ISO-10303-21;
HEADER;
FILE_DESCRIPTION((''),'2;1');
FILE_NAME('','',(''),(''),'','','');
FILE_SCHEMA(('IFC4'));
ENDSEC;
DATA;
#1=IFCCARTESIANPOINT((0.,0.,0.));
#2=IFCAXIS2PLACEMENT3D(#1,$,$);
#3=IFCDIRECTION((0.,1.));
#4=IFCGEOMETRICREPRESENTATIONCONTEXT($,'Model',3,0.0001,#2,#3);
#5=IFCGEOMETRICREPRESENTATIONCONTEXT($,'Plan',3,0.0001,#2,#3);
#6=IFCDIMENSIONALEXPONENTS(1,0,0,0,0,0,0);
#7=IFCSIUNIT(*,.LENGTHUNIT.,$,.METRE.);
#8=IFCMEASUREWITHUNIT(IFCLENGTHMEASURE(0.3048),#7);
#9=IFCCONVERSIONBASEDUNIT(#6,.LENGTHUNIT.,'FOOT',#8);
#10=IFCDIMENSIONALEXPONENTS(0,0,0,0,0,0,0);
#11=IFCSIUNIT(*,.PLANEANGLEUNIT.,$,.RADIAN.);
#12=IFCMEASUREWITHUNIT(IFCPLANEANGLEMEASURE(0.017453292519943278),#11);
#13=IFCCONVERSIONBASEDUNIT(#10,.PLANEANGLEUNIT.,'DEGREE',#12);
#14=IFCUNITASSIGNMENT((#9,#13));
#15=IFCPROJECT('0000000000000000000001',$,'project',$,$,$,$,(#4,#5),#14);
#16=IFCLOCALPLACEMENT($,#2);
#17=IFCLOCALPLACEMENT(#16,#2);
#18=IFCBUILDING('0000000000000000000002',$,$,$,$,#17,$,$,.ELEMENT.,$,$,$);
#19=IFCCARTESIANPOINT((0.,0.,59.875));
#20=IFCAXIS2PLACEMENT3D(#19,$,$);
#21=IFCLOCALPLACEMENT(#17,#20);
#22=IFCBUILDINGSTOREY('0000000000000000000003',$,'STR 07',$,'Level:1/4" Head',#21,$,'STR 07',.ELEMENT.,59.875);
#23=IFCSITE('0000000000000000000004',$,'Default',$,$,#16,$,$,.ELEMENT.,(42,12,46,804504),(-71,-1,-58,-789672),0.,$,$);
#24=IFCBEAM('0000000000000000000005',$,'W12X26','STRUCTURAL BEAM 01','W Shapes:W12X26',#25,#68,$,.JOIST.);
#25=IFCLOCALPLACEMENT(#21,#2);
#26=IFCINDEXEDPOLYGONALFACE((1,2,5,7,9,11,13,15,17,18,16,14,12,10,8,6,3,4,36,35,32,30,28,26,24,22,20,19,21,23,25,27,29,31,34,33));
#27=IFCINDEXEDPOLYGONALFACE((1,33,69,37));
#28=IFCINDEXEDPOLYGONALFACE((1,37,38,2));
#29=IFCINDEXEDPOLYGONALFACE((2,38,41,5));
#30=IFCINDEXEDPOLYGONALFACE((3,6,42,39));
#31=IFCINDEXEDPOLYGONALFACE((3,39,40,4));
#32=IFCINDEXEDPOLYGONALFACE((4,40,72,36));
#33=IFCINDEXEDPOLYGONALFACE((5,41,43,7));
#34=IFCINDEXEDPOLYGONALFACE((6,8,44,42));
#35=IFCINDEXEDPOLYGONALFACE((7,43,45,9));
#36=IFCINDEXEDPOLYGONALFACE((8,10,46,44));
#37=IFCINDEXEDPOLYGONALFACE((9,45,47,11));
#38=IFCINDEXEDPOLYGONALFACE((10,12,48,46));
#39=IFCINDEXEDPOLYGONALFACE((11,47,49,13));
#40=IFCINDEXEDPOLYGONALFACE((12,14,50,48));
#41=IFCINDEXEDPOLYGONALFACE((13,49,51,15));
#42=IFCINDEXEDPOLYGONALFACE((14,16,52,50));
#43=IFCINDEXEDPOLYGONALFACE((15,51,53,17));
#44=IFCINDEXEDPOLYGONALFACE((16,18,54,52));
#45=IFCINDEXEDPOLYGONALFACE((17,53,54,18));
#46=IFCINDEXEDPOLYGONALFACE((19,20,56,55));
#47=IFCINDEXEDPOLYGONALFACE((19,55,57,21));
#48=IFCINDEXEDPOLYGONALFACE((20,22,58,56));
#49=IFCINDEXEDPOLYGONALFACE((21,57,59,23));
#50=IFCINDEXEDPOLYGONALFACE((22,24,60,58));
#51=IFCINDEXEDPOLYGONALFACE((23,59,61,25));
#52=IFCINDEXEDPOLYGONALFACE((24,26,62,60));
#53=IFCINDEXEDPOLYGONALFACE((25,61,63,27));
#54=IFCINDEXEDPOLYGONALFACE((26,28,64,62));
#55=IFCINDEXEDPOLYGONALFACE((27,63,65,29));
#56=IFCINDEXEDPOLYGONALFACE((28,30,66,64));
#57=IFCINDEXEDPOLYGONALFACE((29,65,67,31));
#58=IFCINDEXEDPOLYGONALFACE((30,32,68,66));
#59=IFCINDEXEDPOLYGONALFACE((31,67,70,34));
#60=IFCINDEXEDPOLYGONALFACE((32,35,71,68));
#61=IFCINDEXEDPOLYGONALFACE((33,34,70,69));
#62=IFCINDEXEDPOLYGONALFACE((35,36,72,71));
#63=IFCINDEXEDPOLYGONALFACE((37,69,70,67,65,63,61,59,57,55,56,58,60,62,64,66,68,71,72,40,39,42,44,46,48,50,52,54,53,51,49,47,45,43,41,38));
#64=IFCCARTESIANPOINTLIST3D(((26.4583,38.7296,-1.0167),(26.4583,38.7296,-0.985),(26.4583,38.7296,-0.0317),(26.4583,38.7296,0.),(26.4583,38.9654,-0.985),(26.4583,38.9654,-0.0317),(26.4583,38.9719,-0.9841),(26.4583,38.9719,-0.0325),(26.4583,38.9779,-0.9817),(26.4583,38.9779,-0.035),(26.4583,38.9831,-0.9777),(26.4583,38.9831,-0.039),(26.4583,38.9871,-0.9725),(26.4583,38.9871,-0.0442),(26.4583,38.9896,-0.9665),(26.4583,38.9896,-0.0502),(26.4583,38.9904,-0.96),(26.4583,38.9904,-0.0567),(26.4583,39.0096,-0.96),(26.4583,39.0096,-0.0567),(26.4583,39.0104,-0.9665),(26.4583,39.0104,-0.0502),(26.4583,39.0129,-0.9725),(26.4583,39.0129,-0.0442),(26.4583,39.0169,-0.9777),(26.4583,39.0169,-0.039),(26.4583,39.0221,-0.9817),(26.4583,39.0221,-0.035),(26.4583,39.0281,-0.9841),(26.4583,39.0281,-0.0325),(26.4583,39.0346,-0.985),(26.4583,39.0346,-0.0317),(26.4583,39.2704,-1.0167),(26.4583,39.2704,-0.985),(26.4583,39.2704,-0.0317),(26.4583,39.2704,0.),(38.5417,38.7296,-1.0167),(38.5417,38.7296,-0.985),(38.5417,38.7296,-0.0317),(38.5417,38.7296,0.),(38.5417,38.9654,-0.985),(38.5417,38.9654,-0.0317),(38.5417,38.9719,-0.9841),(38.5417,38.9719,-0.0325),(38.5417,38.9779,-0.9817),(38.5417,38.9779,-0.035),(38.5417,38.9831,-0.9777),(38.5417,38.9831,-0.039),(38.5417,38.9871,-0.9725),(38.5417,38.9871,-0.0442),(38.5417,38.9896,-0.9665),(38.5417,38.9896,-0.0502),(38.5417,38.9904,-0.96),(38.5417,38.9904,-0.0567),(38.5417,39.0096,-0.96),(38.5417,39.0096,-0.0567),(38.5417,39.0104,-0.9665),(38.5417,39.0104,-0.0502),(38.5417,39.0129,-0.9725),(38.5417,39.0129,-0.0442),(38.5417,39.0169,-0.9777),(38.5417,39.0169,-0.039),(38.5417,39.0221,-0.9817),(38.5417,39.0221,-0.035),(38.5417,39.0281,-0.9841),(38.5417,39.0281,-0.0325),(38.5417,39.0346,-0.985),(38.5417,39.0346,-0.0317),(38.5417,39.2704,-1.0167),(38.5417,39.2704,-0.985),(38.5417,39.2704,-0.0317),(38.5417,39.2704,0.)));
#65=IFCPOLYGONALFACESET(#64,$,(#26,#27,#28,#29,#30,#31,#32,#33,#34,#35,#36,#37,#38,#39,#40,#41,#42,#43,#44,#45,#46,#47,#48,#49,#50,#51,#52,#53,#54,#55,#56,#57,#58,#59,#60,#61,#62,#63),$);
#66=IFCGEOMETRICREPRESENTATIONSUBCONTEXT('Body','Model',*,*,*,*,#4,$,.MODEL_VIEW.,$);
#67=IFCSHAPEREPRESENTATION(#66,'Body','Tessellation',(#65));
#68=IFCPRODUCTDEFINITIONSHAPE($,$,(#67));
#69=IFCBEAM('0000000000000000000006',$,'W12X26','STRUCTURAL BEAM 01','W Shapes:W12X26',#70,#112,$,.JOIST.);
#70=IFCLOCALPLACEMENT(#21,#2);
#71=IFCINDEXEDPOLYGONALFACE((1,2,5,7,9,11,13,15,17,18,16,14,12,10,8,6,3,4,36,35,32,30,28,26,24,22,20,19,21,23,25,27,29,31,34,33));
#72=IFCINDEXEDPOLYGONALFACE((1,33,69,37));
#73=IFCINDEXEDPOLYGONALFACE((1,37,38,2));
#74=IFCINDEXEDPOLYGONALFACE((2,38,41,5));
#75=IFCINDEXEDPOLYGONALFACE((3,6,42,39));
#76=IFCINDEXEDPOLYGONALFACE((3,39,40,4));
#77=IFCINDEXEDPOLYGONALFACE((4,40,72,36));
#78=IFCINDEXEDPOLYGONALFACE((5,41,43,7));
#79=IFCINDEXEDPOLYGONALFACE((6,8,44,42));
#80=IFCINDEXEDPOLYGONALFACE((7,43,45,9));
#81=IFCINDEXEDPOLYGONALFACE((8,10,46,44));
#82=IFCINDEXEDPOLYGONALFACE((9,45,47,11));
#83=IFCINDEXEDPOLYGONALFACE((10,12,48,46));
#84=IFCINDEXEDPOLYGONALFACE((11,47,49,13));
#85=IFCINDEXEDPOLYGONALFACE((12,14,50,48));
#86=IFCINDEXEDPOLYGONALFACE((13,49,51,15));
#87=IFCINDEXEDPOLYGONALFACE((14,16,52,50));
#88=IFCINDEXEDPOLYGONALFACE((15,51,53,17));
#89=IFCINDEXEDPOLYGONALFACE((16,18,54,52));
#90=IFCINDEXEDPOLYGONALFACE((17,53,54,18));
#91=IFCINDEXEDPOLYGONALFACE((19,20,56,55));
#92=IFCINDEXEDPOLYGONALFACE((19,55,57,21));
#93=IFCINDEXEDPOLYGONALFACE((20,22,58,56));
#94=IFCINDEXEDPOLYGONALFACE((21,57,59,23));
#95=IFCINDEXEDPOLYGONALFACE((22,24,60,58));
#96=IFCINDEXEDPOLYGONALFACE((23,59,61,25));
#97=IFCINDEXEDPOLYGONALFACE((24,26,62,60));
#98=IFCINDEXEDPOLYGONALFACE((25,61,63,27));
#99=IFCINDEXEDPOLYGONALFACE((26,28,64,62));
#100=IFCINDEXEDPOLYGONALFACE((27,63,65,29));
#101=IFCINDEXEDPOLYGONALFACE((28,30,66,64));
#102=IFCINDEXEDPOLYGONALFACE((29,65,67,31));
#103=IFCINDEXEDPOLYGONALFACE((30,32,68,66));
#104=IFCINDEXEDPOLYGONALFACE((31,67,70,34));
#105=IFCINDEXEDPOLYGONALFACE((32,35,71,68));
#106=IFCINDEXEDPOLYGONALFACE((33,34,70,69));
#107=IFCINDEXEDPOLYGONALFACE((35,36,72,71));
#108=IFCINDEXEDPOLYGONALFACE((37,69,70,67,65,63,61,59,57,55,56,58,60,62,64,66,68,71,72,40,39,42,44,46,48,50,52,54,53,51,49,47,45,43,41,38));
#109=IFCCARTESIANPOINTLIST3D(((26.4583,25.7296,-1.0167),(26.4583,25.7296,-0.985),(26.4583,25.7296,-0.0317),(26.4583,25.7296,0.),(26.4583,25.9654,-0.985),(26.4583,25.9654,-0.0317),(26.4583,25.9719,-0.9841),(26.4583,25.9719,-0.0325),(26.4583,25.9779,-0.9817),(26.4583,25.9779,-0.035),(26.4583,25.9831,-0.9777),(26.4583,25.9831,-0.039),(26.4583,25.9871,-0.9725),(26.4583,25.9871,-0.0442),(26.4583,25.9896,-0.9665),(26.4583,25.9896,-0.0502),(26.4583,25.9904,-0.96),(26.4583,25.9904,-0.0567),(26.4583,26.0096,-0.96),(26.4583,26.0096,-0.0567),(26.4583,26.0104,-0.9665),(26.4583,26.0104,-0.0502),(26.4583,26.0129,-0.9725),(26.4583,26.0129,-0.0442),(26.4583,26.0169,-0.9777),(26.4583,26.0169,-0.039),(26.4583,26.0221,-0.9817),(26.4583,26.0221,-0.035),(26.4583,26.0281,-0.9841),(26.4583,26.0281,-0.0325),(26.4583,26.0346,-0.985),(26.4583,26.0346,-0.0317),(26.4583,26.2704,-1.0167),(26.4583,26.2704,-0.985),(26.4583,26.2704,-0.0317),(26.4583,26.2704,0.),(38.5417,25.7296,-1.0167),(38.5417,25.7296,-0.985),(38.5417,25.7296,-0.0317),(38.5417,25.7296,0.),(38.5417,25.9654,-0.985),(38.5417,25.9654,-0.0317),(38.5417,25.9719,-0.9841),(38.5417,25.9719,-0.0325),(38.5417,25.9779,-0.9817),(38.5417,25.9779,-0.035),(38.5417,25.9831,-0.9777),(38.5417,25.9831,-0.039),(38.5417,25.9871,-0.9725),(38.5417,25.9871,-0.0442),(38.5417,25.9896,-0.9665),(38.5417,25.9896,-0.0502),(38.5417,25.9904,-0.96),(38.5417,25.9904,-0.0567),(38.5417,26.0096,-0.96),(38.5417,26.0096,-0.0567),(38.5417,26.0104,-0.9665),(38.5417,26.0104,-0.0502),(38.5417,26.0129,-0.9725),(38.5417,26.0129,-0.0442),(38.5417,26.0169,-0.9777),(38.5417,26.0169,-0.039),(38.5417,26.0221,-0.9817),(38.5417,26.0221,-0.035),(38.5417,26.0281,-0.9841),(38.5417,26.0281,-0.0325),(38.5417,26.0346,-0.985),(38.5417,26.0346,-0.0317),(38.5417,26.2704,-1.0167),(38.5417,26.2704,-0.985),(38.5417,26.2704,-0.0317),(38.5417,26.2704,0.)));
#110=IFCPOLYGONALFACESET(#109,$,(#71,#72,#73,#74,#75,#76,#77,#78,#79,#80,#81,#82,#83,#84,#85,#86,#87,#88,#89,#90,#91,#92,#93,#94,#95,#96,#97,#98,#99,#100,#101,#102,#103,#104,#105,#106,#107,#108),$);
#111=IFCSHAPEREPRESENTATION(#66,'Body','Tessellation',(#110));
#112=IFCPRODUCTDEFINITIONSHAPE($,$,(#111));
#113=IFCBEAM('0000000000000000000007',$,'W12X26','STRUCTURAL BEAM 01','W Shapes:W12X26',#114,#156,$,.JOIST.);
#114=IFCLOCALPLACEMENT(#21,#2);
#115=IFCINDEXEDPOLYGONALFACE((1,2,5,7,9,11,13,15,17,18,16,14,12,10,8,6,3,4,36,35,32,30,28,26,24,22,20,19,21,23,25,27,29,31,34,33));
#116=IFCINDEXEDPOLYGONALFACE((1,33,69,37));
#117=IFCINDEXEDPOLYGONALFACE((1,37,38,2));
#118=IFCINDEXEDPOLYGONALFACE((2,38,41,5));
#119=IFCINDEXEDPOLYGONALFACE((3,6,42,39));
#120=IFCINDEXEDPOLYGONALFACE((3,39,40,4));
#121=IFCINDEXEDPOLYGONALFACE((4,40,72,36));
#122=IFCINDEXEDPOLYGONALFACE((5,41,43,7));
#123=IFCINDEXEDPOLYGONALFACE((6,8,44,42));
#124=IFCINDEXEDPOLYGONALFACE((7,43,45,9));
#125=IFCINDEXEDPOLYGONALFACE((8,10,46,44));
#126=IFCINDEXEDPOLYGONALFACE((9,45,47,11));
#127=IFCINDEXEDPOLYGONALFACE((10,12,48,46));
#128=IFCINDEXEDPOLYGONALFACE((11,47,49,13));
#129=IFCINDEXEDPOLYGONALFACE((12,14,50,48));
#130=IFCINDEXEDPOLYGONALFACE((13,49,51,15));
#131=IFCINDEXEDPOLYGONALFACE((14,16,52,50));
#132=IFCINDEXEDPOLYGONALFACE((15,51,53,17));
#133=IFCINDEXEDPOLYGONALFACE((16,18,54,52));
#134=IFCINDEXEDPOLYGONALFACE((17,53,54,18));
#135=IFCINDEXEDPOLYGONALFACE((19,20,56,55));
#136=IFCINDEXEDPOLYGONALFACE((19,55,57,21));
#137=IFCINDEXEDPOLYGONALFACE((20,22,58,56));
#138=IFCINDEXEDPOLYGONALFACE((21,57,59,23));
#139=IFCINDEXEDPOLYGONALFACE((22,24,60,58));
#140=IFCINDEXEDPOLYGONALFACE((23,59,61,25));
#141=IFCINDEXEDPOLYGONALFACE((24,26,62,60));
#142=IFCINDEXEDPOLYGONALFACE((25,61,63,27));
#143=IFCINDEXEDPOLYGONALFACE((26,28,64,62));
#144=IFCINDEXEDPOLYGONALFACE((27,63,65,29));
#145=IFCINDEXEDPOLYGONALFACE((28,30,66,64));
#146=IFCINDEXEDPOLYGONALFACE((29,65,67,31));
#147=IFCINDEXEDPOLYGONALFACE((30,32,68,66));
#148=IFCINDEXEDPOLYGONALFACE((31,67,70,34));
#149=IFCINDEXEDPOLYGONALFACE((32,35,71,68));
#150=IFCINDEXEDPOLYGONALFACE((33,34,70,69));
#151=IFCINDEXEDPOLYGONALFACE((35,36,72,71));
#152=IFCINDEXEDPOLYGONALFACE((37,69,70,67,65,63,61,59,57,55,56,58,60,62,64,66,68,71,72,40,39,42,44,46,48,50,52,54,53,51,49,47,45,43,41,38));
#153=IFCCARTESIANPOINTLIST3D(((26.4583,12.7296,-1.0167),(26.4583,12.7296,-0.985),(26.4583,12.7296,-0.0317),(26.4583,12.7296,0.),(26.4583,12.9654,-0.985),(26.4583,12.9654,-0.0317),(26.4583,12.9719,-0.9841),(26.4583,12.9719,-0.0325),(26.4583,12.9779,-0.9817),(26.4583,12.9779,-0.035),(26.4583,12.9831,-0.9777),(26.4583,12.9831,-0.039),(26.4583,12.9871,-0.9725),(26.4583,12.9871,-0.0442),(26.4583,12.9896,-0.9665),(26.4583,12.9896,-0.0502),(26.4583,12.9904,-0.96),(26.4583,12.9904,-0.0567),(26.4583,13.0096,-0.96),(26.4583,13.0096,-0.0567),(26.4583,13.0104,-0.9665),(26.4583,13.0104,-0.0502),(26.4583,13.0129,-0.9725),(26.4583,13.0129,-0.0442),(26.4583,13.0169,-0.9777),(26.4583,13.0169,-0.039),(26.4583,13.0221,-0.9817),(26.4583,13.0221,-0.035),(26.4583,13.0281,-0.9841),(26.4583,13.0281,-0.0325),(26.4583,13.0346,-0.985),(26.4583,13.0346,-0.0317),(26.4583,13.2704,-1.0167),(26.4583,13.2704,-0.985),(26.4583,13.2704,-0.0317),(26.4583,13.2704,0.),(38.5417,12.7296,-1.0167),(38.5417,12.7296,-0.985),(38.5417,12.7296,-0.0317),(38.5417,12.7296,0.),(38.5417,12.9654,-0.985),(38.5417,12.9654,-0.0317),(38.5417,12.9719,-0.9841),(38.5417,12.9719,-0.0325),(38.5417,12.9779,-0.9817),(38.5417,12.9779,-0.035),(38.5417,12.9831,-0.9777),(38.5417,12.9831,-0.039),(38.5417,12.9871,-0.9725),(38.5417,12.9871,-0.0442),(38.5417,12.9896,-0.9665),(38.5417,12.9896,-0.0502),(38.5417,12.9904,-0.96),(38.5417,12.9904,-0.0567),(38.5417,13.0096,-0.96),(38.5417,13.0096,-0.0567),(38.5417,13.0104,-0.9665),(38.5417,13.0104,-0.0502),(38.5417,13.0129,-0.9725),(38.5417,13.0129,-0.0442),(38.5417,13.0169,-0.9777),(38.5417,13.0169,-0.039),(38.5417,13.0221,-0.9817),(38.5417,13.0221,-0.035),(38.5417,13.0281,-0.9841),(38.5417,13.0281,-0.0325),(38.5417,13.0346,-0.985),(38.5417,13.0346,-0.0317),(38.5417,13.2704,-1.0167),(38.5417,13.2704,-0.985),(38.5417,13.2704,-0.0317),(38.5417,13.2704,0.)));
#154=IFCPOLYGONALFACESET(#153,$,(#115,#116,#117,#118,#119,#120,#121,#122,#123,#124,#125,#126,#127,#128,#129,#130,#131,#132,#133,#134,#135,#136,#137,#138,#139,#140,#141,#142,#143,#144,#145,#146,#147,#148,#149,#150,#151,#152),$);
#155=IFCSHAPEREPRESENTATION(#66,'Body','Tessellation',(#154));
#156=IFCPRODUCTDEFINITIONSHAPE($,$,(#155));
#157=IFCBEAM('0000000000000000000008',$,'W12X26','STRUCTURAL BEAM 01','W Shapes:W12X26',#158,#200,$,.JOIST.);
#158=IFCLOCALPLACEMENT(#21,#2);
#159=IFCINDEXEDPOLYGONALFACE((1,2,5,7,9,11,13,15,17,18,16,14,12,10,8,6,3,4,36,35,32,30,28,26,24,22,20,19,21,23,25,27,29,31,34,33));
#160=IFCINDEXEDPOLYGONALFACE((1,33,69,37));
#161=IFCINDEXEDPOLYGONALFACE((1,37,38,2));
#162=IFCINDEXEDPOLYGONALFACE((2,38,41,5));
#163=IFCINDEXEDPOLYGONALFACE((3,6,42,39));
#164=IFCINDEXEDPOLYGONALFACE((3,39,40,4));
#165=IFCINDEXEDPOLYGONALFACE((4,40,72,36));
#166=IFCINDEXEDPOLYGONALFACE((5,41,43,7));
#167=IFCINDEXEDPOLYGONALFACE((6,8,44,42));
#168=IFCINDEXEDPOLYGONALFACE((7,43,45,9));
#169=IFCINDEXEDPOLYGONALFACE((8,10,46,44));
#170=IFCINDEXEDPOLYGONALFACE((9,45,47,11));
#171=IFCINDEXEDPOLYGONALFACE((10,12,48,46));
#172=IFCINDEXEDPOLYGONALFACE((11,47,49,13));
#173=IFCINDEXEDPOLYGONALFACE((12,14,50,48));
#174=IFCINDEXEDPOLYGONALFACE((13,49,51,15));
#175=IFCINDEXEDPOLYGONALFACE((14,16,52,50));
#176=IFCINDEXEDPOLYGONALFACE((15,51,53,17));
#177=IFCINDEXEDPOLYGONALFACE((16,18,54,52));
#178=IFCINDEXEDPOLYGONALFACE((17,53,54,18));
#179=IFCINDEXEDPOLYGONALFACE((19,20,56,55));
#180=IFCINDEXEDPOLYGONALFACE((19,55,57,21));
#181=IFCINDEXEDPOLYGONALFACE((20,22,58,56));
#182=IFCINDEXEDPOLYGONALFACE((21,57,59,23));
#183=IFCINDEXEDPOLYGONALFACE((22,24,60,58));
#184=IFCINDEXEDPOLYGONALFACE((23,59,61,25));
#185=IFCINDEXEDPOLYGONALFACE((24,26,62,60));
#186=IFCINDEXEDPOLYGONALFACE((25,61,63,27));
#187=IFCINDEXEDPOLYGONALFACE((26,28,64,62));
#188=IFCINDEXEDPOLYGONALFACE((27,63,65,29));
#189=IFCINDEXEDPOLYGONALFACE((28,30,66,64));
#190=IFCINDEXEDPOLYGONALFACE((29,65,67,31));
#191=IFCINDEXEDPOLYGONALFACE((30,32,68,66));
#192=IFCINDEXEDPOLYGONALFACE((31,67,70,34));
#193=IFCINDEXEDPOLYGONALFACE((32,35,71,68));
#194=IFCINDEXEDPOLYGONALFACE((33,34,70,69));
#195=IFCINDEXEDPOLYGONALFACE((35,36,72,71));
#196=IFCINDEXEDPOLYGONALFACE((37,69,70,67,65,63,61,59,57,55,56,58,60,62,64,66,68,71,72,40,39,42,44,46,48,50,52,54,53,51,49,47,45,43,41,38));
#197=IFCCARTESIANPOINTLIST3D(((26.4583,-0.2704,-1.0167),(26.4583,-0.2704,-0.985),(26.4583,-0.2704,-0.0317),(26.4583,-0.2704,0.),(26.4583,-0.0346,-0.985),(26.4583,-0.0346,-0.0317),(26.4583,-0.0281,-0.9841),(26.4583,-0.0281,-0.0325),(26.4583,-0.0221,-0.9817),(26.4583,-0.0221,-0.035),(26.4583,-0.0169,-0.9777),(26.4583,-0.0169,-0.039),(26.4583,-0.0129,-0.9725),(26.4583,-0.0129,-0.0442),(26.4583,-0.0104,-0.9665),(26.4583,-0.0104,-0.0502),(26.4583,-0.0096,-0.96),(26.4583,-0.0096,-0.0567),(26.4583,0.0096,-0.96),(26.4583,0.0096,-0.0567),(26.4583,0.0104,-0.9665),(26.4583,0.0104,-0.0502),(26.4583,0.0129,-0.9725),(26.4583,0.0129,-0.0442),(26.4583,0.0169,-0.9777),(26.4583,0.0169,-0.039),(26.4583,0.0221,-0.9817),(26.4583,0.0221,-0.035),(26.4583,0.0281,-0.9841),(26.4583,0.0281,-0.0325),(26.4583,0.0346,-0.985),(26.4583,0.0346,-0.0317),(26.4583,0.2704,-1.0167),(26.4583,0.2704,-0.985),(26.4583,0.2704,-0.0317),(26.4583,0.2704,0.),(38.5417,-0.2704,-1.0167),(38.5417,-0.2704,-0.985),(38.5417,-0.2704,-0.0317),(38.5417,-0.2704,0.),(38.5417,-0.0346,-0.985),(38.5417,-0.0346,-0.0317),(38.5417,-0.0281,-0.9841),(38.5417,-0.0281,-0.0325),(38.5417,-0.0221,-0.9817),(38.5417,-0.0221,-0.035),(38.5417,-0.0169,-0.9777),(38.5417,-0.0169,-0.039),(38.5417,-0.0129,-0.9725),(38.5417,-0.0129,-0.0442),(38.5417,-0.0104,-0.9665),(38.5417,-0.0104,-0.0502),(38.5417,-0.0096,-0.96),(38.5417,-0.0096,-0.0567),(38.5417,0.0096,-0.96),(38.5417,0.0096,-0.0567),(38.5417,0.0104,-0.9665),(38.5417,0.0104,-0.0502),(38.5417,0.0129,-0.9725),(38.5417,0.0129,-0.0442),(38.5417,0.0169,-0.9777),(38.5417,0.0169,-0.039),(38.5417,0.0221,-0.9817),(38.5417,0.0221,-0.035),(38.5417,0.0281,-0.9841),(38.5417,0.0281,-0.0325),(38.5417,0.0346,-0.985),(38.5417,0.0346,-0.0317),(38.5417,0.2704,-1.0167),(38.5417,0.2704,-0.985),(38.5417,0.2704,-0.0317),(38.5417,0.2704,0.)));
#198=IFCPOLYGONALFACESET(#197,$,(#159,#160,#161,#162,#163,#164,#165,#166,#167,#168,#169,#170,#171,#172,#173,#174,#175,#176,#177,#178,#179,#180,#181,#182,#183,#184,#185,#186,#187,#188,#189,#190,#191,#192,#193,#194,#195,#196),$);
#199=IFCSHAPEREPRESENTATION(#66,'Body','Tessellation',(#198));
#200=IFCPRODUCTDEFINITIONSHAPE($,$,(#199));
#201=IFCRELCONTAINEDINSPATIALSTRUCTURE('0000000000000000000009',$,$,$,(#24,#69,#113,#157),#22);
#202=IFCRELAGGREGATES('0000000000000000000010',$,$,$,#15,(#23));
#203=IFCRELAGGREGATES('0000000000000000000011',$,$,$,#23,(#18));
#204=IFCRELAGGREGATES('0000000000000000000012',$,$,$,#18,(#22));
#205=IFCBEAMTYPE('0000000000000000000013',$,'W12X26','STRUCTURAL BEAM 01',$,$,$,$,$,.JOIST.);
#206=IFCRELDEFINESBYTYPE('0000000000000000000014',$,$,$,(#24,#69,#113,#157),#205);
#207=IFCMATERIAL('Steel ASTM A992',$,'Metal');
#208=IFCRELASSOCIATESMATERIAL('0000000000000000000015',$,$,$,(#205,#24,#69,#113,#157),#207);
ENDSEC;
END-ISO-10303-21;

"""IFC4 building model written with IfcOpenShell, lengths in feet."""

from ifc_helpers import new_model, entity, si_unit, converted_unit, direction, frame, origin, place, context, subcontext, project, spatial, line, arc, indexed_curve, outline, extrude, source, transform, mapped, material, type_object, type_shapes, element, save


model = new_model("IFC4")

# Units and contexts
model_context = context("Model", 3, precision=0.0001, world=origin(), true_north=direction((0.0, 1.0)))
plan_context = context("Plan", 3, precision=0.0001, world=origin(), true_north=direction((0.0, 1.0)))
body_context = subcontext(model_context, "Body", "Model", "MODEL_VIEW")
ifc_project = project(units=[converted_unit("LENGTHUNIT", "FOOT", entity("IfcLengthMeasure", 0.3048), si_unit("LENGTHUNIT", "METRE"), dimensions=[1, 0, 0, 0, 0, 0, 0]), converted_unit("PLANEANGLEUNIT", "DEGREE", entity("IfcPlaneAngleMeasure", 0.017453292519943278), si_unit("PLANEANGLEUNIT", "RADIAN"), dimensions=[0, 0, 0, 0, 0, 0, 0])], contexts=[model_context, plan_context])

# Site, building, storey
site_placement = place(None, origin())
site = spatial("IfcSite", under=ifc_project, at=site_placement, Name="Default", CompositionType="ELEMENT", RefLatitude=(42, 12, 46, 804504), RefLongitude=(-71, -1, -58, -789672), RefElevation=0.0)
building_placement = place(site_placement, origin())
building = spatial("IfcBuilding", under=site, at=building_placement, CompositionType="ELEMENT")
storey_placement = place(building_placement, frame((0.0, 0.0, 59.875)))
storey = spatial("IfcBuildingStorey", under=building, at=storey_placement, Name="STR 07", ObjectType="Level:1/4\" Head", LongName="STR 07", CompositionType="ELEMENT", Elevation=59.875)

# Shared definitions
ifc_material = material(Name="Steel ASTM A992", Category="Metal")

# Beams
beam_type_1 = type_object("IfcBeamType", Name="W12X26", Description="STRUCTURAL BEAM 01", PredefinedType="JOIST", material=ifc_material)
shared_shape_1 = source(origin(), body_context, "Body", "SweptSolid", [
    extrude(outline(indexed_curve([(-0.2704, -0.4767), (-0.2704, -0.5083), (0.2704, -0.5083), (0.2704, -0.4767), (0.0346, -0.4767), (0.0169, -0.4693), (0.0096, -0.4517), (0.0096, 0.4517), (0.0169, 0.4693), (0.0346, 0.4767), (0.2704, 0.4767), (0.2704, 0.5083), (-0.2704, 0.5083), (-0.2704, 0.4767), (-0.0346, 0.4767), (-0.0169, 0.4693), (-0.0096, 0.4517), (-0.0096, -0.4517), (-0.0169, -0.4693), (-0.0346, -0.4767)], segments=[line(1, 2, 3, 4, 5), arc(5, 6, 7), line(7, 8), arc(8, 9, 10), line(10, 11, 12, 13, 14, 15), arc(15, 16, 17), line(17, 18), arc(18, 19, 20), line(20, 1)], self_intersect=False)), frame((-6.165, 0.0, 0.0), z_axis=(-1.0, 0.0, 0.0), x_axis=(0.0, -1.0, 0.0)), (0.0, 0.0, -1.0), 12.0833),
])
type_shapes(beam_type_1, [shared_shape_1])
for number, where, name in (
    (1, (32.6234, 39.0, -0.5083), "W12X26"),
    (2, (32.6234, 26.0, -0.5083), "W12X26"),
    (3, (32.6234, 13.0, -0.5083), "W12X26"),
    (4, (32.6234, 0.0, -0.5083), "W12X26"),
):
    element("IfcBeam", number, at=place(storey_placement, frame(where)), inside=storey, type_object=beam_type_1, material=ifc_material, Name=name, Description="STRUCTURAL BEAM 01", ObjectType="W Shapes:W12X26", PredefinedType="JOIST", context=body_context, shape_type="MappedRepresentation", body=[
        mapped(shared_shape_1, transform((0.0, 0.0, 0.0), scale=1.0)),
    ])

save(model, "model.ifc")
